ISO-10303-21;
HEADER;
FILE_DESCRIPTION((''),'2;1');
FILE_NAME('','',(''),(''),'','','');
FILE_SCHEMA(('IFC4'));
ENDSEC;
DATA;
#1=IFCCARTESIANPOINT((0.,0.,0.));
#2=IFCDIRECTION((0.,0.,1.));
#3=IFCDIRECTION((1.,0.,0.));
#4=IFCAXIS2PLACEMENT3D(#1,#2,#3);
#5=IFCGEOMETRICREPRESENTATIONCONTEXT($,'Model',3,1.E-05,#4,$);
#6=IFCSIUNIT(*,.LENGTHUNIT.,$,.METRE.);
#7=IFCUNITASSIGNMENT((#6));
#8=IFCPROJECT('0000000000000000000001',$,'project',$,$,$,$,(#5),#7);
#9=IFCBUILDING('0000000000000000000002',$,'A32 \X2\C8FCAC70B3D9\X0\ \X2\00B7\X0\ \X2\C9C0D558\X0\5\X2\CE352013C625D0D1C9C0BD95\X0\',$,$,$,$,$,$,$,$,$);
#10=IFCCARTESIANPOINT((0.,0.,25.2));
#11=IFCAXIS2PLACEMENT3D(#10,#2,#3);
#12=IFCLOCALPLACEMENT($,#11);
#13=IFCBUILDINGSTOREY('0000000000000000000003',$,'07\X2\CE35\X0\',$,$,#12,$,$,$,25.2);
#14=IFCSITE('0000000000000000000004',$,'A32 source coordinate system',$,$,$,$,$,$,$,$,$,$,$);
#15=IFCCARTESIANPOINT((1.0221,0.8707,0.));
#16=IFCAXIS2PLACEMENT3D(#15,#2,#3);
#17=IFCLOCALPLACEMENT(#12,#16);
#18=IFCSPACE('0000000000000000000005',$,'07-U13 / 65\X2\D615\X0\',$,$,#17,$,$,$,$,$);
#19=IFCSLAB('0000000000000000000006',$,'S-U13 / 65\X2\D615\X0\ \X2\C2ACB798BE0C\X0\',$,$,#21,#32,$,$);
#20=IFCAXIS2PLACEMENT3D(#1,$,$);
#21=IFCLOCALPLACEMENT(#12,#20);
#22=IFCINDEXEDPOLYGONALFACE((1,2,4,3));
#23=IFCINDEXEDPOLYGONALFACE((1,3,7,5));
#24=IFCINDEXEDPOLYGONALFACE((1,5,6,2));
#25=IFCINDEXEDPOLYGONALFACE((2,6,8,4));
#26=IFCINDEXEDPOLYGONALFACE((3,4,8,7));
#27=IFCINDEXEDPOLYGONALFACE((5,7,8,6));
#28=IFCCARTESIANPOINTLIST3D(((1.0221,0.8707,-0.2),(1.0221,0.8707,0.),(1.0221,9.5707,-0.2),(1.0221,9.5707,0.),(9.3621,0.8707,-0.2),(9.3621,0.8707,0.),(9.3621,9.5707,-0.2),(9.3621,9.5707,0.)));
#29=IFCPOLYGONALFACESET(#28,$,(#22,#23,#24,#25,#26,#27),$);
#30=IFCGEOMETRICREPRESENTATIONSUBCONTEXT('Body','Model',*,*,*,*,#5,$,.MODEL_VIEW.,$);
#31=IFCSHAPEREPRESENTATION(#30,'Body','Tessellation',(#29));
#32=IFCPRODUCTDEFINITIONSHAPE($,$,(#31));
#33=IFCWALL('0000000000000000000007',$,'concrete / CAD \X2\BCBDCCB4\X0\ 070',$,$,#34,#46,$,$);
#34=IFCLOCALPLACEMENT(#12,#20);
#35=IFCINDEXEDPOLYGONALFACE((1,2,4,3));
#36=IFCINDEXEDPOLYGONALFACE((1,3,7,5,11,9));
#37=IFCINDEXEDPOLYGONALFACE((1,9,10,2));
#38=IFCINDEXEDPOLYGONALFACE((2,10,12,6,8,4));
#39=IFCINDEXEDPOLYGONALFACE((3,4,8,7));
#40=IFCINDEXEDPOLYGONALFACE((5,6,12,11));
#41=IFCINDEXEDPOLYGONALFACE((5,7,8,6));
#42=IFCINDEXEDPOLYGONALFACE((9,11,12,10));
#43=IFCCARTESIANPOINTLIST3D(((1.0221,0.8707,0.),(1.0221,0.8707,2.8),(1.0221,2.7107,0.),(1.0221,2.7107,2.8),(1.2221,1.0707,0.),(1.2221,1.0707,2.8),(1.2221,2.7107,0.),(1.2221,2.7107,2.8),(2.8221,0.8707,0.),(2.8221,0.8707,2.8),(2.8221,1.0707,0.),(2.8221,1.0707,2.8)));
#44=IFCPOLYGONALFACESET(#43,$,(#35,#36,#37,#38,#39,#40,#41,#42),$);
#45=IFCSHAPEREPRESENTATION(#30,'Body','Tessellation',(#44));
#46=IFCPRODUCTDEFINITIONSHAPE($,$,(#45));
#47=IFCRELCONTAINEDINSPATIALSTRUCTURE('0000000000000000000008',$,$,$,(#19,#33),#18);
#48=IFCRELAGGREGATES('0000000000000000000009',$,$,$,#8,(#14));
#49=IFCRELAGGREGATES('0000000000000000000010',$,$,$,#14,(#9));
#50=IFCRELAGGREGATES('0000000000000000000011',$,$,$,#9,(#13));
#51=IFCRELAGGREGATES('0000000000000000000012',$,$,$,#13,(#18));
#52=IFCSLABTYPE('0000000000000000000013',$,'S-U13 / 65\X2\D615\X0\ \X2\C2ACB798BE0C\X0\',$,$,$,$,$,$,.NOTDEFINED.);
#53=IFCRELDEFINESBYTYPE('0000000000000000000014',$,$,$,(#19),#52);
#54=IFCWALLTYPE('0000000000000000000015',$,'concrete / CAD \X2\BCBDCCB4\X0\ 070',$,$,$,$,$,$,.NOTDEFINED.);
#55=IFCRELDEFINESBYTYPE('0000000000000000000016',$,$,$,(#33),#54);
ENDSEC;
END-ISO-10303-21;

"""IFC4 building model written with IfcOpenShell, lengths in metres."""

from ifc_helpers import new_model, si_unit, frame, origin, origin_with_axes, place, context, subcontext, project, spatial, polyline, outline, extrude, source, transform, mapped, type_object, type_shapes, element, save


model = new_model("IFC4")

# Units and contexts
model_context = context("Model", 3, precision=1e-05, world=origin_with_axes())
body_context = subcontext(model_context, "Body", "Model", "MODEL_VIEW")
ifc_project = project(units=[si_unit("LENGTHUNIT", "METRE")], contexts=[model_context])

# Site, building, storey, space
storey_placement = place(None, frame((0.0, 0.0, 25.2), z_axis=(0.0, 0.0, 1.0), x_axis=(1.0, 0.0, 0.0)))
space_placement = place(storey_placement, frame((1.0221, 0.8707, 0.0), z_axis=(0.0, 0.0, 1.0), x_axis=(1.0, 0.0, 0.0)))
site = spatial("IfcSite", under=ifc_project, Name="A32 source coordinate system")
building = spatial("IfcBuilding", under=site, Name="A32 주거동 · 지하5층–옥탑지붕")
storey = spatial("IfcBuildingStorey", under=building, at=storey_placement, Name="07층", Elevation=25.2)
space = spatial("IfcSpace", under=storey, at=space_placement, Name="07-U13 / 65형")

# Slab
slab_type = type_object("IfcSlabType", Name="S-U13 / 65형 슬래브", PredefinedType="NOTDEFINED")
shared_shape_1 = source(origin(), body_context, "Body", "SweptSolid", [
    extrude(outline(polyline([(0.0, 0.0), (0.0, 8.7), (8.34, 8.7), (8.34, 0.0), (0.0, 0.0)])), frame((0.0, 0.0, -0.2)), (0.0, 0.0, 1.0), 0.2),
])
type_shapes(slab_type, [shared_shape_1])
slab_placement = place(space_placement, origin_with_axes())
element("IfcSlab", 1, at=slab_placement, inside=space, type_object=slab_type, Name="S-U13 / 65형 슬래브", context=body_context, shape_type="MappedRepresentation", body=[
    mapped(shared_shape_1, transform((0.0, 0.0, 0.0), scale=1.0)),
])

# Wall
wall_type_1 = type_object("IfcWallType", Name="concrete / CAD 벽체 070", PredefinedType="NOTDEFINED")
shared_shape_2 = source(origin(), body_context, "Body", "SweptSolid", [
    extrude(outline(polyline([(0.2, 1.84), (0.2, 0.2), (1.8, 0.2), (1.8, 0.0), (0.0, 0.0), (0.0, 1.84), (0.2, 1.84)])), origin(), (0.0, 0.0, 1.0), 2.8),
])
type_shapes(wall_type_1, [shared_shape_2])
wall_1_placement = place(space_placement, origin_with_axes())
element("IfcWall", 2, at=wall_1_placement, inside=space, type_object=wall_type_1, Name="concrete / CAD 벽체 070", context=body_context, shape_type="MappedRepresentation", body=[
    mapped(shared_shape_2, transform((0.0, 0.0, 0.0), scale=1.0)),
])

save(model, "model.ifc")
